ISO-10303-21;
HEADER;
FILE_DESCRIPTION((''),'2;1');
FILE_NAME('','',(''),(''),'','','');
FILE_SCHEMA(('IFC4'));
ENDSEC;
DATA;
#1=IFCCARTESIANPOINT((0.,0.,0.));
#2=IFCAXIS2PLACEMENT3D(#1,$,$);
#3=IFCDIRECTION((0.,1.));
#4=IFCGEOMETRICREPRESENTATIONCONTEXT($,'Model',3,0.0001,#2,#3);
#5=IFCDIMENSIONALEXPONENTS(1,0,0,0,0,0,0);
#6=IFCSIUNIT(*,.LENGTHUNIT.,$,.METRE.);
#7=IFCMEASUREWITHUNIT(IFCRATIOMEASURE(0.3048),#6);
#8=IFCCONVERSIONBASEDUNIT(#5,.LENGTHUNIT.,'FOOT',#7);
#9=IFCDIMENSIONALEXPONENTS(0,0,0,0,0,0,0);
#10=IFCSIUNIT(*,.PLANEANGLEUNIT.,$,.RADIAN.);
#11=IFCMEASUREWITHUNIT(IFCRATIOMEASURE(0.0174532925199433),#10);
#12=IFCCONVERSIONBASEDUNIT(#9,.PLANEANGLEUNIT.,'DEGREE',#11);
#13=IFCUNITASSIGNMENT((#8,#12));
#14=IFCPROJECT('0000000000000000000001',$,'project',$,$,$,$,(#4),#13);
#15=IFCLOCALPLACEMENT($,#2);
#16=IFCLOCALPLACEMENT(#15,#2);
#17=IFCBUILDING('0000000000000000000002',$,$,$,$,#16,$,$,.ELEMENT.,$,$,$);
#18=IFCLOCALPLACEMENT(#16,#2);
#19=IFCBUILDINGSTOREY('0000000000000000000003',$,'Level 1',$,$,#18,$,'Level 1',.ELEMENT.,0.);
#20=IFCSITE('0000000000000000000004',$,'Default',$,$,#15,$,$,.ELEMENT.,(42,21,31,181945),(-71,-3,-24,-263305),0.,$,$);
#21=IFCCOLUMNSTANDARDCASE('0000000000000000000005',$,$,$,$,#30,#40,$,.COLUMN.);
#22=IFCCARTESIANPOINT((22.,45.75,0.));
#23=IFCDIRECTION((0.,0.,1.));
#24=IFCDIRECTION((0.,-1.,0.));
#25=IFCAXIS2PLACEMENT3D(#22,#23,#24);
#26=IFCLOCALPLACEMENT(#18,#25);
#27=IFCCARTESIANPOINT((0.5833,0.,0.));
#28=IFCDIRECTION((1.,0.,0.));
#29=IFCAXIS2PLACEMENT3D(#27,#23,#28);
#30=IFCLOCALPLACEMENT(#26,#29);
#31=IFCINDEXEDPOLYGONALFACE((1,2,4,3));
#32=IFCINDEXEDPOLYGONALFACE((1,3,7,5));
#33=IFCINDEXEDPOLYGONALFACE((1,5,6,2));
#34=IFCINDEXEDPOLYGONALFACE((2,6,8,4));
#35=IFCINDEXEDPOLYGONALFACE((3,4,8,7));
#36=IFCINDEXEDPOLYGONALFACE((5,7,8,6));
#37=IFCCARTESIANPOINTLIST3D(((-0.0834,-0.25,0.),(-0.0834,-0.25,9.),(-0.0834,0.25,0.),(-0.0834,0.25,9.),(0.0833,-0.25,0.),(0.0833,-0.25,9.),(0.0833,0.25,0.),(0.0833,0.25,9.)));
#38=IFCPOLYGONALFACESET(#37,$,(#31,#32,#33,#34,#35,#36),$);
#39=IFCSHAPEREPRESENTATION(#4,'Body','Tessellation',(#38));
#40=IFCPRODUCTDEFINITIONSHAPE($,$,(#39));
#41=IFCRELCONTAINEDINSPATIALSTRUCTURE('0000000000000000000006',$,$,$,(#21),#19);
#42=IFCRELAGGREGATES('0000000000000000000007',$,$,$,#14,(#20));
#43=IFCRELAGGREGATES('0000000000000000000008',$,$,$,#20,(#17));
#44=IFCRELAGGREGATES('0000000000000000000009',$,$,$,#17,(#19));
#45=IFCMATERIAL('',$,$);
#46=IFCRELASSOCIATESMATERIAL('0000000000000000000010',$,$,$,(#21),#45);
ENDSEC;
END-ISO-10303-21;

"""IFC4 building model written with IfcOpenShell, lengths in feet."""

from ifc_helpers import new_model, entity, si_unit, converted_unit, direction, frame, origin, place, context, project, spatial, rectangle, extrude, material, element, save


model = new_model("IFC4")

# Units and contexts
model_context = context("Model", 3, precision=0.0001, world=origin(), true_north=direction((0.0, 1.0)))
ifc_project = project(units=[converted_unit("LENGTHUNIT", "FOOT", entity("IfcRatioMeasure", 0.3048), si_unit("LENGTHUNIT", "METRE"), dimensions=[1, 0, 0, 0, 0, 0, 0]), converted_unit("PLANEANGLEUNIT", "DEGREE", entity("IfcRatioMeasure", 0.0174532925199433), si_unit("PLANEANGLEUNIT", "RADIAN"), dimensions=[0, 0, 0, 0, 0, 0, 0])], contexts=[model_context])

# Site, building, storey
site_placement = place(None, origin())
site = spatial("IfcSite", under=ifc_project, at=site_placement, Name="Default", CompositionType="ELEMENT", RefLatitude=(42, 21, 31, 181945), RefLongitude=(-71, -3, -24, -263305), RefElevation=0.0)
building_placement = place(site_placement, origin())
building = spatial("IfcBuilding", under=site, at=building_placement, CompositionType="ELEMENT")
storey_placement = place(building_placement, origin())
storey = spatial("IfcBuildingStorey", under=building, at=storey_placement, Name="Level 1", LongName="Level 1", CompositionType="ELEMENT", Elevation=0.0)

# Column
ifc_material_1 = material(Name="")
placement_1 = place(storey_placement, frame((22.0, 45.75, 0.0), z_axis=(0.0, 0.0, 1.0), x_axis=(0.0, -1.0, 0.0)))
for number, where, z_axis, x_axis in (
    (1, (0.5833, 0.0, 0.0), (0.0, 0.0, 1.0), (1.0, 0.0, 0.0)),
):
    element("IfcColumnStandardCase", number, at=place(placement_1, frame(where, z_axis=z_axis, x_axis=x_axis)), inside=storey, material=ifc_material_1, PredefinedType="COLUMN", context=model_context, shape_type="SweptSolid", body=[
        extrude(rectangle(XDim=0.1667, YDim=0.5), origin(), (0.0, 0.0, 1.0), 9.0),
    ])

save(model, "model.ifc")
